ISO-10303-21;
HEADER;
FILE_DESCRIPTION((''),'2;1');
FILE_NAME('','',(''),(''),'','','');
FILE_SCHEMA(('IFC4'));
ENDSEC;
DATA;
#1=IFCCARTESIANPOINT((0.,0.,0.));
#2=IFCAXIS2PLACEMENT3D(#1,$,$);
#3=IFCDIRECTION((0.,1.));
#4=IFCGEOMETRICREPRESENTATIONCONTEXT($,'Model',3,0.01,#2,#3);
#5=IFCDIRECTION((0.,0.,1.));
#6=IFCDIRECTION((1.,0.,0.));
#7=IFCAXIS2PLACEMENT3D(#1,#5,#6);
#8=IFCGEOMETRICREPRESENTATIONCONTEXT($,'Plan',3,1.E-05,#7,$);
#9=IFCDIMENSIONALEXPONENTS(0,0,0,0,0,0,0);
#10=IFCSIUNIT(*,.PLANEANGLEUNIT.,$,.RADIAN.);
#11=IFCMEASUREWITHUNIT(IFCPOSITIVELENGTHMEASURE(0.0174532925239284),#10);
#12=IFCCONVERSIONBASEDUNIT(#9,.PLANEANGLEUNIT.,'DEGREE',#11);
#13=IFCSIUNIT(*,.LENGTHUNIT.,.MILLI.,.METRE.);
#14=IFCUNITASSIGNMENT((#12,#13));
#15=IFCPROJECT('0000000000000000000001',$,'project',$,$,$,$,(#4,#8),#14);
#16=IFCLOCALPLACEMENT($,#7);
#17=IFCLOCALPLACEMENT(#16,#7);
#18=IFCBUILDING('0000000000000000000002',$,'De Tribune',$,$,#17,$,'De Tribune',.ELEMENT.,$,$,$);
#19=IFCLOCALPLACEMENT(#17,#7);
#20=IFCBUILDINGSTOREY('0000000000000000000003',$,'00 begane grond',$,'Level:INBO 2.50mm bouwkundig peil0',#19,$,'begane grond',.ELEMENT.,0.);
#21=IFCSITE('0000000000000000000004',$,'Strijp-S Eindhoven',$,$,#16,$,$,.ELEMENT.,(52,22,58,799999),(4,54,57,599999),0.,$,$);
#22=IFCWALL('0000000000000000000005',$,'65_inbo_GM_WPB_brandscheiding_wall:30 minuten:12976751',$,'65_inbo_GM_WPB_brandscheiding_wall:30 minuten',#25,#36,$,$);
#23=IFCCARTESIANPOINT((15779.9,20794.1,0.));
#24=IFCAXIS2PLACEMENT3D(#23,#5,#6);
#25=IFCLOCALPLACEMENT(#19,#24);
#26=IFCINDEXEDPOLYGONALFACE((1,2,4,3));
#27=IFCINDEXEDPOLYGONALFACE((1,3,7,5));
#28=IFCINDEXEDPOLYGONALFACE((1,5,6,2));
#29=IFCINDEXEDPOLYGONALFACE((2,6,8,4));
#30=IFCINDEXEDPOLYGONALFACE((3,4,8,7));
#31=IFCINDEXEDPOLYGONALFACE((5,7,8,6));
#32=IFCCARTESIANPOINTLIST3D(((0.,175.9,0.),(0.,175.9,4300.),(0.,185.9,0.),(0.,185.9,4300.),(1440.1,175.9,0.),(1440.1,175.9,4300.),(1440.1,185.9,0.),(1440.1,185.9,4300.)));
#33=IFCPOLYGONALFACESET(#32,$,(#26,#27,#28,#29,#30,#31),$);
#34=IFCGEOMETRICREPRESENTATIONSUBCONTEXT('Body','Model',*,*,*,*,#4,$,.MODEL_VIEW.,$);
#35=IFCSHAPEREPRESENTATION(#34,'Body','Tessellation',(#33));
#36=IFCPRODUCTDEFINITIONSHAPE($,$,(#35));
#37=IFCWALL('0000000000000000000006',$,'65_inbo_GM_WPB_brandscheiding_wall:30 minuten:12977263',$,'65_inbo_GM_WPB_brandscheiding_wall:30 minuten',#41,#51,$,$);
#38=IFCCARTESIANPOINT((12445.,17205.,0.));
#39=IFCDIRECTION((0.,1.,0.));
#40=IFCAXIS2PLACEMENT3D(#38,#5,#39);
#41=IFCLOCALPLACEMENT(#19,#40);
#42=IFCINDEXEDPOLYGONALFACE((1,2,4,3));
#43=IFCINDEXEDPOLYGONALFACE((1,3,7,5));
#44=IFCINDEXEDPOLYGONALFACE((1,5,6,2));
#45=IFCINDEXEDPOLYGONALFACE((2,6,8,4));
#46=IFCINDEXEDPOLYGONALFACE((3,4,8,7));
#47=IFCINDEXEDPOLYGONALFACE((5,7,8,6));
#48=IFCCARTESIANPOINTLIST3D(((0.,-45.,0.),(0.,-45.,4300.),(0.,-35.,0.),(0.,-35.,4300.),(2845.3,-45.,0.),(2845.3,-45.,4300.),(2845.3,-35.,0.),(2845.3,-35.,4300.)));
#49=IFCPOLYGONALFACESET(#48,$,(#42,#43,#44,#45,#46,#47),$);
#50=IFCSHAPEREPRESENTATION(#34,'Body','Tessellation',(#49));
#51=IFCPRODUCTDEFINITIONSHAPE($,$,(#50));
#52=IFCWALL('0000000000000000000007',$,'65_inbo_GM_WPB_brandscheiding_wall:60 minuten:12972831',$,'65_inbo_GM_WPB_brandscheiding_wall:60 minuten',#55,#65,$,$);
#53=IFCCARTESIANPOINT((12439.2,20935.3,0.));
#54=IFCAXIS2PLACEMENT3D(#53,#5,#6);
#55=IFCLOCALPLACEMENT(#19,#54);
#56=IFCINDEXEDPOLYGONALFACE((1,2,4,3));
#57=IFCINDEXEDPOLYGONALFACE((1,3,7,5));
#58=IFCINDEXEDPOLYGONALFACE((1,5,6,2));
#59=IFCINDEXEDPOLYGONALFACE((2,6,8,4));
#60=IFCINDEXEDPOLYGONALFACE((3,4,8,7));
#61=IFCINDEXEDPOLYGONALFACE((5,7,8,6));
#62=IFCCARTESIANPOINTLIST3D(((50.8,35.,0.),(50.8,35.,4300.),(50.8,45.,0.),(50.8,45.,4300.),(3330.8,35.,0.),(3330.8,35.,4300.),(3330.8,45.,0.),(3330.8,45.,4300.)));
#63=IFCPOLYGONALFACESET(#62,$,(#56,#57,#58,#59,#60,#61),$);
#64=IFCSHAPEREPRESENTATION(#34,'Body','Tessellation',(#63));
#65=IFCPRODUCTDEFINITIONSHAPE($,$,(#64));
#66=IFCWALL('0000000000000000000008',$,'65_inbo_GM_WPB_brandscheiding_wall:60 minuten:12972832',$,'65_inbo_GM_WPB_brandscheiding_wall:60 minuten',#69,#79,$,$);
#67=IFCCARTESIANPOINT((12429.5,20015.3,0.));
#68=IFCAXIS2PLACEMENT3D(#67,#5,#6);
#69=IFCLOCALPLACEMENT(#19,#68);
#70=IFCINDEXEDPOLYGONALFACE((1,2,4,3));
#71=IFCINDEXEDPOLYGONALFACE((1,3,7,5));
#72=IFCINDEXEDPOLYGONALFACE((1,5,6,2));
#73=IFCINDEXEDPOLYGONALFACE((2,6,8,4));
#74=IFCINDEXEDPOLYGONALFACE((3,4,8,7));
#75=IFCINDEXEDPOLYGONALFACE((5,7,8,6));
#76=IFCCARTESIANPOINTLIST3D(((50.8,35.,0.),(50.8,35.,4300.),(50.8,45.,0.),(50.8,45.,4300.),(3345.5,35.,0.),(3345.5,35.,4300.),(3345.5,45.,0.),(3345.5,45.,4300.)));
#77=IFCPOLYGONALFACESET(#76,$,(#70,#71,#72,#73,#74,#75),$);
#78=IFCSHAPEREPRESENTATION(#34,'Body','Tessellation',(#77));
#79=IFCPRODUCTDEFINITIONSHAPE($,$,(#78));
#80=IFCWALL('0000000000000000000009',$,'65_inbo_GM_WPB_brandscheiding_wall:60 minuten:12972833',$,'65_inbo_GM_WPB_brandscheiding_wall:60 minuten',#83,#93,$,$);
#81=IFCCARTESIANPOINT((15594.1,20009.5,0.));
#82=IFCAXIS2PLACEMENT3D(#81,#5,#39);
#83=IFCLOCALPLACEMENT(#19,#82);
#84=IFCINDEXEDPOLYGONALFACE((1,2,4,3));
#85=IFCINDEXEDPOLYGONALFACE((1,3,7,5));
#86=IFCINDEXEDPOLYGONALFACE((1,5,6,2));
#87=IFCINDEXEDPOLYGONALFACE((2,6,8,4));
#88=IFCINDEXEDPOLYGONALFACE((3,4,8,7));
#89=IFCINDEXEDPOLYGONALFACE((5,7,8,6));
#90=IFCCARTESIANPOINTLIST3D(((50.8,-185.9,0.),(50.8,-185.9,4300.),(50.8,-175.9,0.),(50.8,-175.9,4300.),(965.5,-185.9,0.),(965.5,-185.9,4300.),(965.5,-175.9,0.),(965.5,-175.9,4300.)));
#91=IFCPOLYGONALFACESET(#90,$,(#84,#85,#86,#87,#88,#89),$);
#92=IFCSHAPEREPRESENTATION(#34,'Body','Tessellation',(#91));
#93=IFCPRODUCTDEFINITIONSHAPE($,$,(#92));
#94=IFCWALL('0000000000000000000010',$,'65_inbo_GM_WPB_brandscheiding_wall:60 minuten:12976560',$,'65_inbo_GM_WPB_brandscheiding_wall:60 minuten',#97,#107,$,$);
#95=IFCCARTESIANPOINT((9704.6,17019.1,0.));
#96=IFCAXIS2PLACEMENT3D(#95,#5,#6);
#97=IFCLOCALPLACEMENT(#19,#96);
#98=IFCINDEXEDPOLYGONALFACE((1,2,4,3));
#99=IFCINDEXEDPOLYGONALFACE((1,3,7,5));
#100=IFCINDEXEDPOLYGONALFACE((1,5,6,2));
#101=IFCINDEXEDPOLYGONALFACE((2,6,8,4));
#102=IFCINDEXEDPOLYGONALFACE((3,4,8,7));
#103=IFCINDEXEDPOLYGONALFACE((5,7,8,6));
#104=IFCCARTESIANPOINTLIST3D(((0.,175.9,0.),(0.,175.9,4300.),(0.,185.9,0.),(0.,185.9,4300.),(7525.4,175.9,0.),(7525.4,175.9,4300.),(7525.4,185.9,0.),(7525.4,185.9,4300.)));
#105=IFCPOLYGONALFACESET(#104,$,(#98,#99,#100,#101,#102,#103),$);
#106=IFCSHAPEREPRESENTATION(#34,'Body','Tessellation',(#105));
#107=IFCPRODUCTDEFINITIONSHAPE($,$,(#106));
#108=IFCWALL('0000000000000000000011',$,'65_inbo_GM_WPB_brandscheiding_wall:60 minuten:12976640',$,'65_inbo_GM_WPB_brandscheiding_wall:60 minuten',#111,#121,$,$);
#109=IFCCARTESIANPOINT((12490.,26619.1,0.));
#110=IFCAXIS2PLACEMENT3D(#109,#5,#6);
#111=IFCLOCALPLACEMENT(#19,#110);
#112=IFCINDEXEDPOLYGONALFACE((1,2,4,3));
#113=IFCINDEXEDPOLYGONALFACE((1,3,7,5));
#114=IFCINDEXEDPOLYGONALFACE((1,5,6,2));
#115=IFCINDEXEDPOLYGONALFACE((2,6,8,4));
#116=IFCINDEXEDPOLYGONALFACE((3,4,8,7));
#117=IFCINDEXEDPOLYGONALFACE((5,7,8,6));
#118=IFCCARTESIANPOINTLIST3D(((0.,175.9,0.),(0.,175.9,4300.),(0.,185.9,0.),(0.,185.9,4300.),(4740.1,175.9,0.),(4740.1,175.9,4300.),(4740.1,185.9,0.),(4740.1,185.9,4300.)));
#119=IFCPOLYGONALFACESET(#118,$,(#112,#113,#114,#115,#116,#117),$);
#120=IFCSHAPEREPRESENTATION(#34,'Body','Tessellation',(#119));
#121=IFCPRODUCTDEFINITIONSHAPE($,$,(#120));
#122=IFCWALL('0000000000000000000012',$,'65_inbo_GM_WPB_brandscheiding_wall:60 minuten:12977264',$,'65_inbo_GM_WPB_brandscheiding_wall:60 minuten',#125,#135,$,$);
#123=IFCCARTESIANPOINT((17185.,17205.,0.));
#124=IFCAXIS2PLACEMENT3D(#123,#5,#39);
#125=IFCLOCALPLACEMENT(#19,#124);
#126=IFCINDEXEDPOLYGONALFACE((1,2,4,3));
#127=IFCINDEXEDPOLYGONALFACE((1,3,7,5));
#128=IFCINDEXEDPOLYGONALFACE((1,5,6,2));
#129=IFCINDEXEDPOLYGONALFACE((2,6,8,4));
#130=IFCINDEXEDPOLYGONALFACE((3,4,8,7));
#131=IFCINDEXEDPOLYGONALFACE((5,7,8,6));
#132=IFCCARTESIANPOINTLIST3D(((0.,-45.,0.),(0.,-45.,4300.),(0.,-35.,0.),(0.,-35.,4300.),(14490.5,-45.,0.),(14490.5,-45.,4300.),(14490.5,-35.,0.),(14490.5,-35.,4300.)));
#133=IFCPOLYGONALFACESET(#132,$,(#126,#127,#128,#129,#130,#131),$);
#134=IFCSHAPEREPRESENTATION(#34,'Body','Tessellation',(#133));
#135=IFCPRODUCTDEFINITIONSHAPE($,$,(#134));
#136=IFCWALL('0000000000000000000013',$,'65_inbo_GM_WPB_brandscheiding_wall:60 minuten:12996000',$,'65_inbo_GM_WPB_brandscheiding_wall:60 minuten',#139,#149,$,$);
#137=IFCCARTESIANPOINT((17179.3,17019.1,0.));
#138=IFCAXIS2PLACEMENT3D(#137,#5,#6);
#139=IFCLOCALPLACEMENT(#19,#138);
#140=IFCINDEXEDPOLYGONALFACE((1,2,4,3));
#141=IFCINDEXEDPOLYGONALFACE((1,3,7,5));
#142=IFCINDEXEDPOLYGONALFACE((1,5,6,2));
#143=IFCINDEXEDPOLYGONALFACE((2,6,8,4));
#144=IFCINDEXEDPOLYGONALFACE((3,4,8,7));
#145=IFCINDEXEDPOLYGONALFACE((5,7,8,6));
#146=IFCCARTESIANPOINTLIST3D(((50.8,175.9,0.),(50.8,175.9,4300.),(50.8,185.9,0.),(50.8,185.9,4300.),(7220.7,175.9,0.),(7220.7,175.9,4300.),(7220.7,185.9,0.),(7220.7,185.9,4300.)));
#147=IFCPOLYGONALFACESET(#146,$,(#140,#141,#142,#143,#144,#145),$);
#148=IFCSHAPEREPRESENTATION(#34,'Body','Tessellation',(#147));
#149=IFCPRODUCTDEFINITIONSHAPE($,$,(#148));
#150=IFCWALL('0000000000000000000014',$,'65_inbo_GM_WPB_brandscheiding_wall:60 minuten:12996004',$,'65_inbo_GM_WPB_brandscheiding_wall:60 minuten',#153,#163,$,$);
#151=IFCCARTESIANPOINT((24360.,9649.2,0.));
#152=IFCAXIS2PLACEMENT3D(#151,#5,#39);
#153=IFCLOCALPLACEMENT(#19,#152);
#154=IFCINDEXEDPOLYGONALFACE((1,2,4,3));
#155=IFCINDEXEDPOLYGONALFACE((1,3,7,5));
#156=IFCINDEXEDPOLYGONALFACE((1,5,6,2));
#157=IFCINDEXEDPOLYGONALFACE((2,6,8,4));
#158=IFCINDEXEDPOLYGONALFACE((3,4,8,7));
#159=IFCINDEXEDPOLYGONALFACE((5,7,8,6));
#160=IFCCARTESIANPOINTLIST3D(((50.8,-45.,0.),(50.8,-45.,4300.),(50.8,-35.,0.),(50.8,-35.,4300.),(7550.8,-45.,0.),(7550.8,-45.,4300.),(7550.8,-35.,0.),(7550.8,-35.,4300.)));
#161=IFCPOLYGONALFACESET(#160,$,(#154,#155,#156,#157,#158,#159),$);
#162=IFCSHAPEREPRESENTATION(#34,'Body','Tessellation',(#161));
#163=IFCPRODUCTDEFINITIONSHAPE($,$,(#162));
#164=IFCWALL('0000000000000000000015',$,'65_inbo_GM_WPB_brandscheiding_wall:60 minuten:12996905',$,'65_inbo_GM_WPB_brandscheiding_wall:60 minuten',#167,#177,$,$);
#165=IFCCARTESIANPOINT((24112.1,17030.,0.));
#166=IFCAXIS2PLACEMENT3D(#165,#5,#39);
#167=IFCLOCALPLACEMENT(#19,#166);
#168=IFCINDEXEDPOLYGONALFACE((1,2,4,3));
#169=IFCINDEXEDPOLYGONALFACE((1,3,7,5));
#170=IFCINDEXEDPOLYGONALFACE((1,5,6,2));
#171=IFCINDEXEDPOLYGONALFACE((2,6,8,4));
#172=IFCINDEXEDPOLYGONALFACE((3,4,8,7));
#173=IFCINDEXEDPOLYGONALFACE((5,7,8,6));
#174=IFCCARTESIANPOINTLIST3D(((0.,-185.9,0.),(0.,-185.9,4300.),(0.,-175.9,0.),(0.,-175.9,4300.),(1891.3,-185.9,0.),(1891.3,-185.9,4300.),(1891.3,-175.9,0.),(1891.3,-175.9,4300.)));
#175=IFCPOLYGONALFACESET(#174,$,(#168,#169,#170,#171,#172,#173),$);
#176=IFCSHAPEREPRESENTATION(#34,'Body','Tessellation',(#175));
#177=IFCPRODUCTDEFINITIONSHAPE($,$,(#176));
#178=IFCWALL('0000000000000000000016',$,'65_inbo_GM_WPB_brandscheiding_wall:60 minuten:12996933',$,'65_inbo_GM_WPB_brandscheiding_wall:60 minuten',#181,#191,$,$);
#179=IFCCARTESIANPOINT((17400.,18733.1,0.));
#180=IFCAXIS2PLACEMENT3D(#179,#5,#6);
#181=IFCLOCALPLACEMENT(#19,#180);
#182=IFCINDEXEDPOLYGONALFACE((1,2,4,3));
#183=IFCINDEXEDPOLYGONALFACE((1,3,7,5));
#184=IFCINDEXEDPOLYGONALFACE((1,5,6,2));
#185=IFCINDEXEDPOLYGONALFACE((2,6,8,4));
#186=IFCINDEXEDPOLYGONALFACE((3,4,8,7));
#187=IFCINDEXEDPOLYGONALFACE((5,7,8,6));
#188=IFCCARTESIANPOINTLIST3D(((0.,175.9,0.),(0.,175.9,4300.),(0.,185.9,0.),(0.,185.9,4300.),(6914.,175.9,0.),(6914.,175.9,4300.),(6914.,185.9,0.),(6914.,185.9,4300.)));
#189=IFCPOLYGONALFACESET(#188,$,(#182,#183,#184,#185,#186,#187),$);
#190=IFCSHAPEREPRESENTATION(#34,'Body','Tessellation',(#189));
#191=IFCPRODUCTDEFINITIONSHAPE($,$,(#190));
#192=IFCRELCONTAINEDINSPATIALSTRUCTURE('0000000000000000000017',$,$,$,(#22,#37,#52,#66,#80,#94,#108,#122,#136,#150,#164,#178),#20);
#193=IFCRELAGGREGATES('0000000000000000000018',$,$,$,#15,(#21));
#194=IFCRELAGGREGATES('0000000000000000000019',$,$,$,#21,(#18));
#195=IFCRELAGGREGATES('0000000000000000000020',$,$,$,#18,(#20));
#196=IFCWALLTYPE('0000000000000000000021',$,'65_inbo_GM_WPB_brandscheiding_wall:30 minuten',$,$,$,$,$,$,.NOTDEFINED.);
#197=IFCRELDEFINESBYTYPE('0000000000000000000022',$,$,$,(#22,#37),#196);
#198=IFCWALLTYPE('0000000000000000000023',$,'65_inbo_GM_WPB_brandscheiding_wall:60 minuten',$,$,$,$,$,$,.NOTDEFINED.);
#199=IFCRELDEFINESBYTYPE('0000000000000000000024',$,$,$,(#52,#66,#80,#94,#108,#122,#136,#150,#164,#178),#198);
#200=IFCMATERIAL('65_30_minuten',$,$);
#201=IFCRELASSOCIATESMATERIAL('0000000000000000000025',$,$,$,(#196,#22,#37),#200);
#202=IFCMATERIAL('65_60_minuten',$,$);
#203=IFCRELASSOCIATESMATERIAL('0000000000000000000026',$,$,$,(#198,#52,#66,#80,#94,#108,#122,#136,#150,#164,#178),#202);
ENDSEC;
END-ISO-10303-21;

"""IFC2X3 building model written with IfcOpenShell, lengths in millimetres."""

from ifc_helpers import new_model, entity, si_unit, converted_unit, direction, frame, frame_2d, origin, origin_with_axes, origin_2d_with_axis, place, context, subcontext, project, spatial, rectangle, extrude, material, type_object, element, save


model = new_model("IFC2X3")

# Units and contexts
model_context = context("Model", 3, precision=0.01, world=origin(), true_north=direction((0.0, 1.0)))
plan_context = context("Plan", 3, precision=1e-05, world=origin_with_axes())
body_context = subcontext(model_context, "Body", "Model", "MODEL_VIEW")
ifc_project = project(units=[converted_unit("PLANEANGLEUNIT", "DEGREE", entity("IfcPositiveLengthMeasure", 0.0174532925239284), si_unit("PLANEANGLEUNIT", "RADIAN"), dimensions=[0, 0, 0, 0, 0, 0, 0]), si_unit("LENGTHUNIT", "METRE", prefix="MILLI")], contexts=[model_context, plan_context])

# Site, building, storey
site_placement = place(None, origin_with_axes())
site = spatial("IfcSite", under=ifc_project, at=site_placement, Name="Strijp-S Eindhoven", CompositionType="ELEMENT", RefLatitude=(52, 22, 58, 799999), RefLongitude=(4, 54, 57, 599999), RefElevation=0.0)
building_placement = place(site_placement, origin_with_axes())
building = spatial("IfcBuilding", under=site, at=building_placement, Name="De Tribune", LongName="De Tribune", CompositionType="ELEMENT")
storey_placement = place(building_placement, origin_with_axes())
storey = spatial("IfcBuildingStorey", under=building, at=storey_placement, Name="00 begane grond", ObjectType="Level:INBO 2.50mm bouwkundig peil0", LongName="begane grond", CompositionType="ELEMENT", Elevation=0.0)

# Shared definitions
ifc_material_1 = material(Name="65_60_minuten")

# Walls
ifc_material_2 = material(Name="65_30_minuten")
wall_type_1 = type_object("IfcWallType", Name="65_inbo_GM_WPB_brandscheiding_wall:30 minuten", PredefinedType="NOTDEFINED", material=ifc_material_2)
wall_1_placement = place(storey_placement, frame((15779.9, 20794.1, 0.0), z_axis=(0.0, 0.0, 1.0), x_axis=(1.0, 0.0, 0.0)))
element("IfcWall", 1, at=wall_1_placement, inside=storey, type_object=wall_type_1, material=ifc_material_2, Name="65_inbo_GM_WPB_brandscheiding_wall:30 minuten:12976751", ObjectType="65_inbo_GM_WPB_brandscheiding_wall:30 minuten", context=body_context, shape_type="SweptSolid", body=[
    extrude(rectangle(XDim=10.0, YDim=1440.1, at=frame_2d((0.0, 0.0), x_axis=(1.0, 0.0))), frame((720.1, 180.9, 0.0), z_axis=(0.0, 0.0, 1.0), x_axis=(0.0, -1.0, 0.0)), (0.0, 0.0, 1.0), 4300.0),
])
wall_2_placement = place(storey_placement, frame((12445.0, 17205.0, 0.0), z_axis=(0.0, 0.0, 1.0), x_axis=(0.0, 1.0, 0.0)))
element("IfcWall", 2, at=wall_2_placement, inside=storey, type_object=wall_type_1, material=ifc_material_2, Name="65_inbo_GM_WPB_brandscheiding_wall:30 minuten:12977263", ObjectType="65_inbo_GM_WPB_brandscheiding_wall:30 minuten", context=body_context, shape_type="SweptSolid", body=[
    extrude(rectangle(XDim=10.0, YDim=2845.3, at=origin_2d_with_axis()), frame((1422.6, -40.0, 0.0), z_axis=(0.0, 0.0, 1.0), x_axis=(0.0, -1.0, 0.0)), (0.0, 0.0, 1.0), 4300.0),
])
wall_type_2 = type_object("IfcWallType", Name="65_inbo_GM_WPB_brandscheiding_wall:60 minuten", PredefinedType="NOTDEFINED", material=ifc_material_1)
wall_3_placement = place(storey_placement, frame((12439.2, 20935.3, 0.0), z_axis=(0.0, 0.0, 1.0), x_axis=(1.0, 0.0, 0.0)))
element("IfcWall", 3, at=wall_3_placement, inside=storey, type_object=wall_type_2, material=ifc_material_1, Name="65_inbo_GM_WPB_brandscheiding_wall:60 minuten:12972831", ObjectType="65_inbo_GM_WPB_brandscheiding_wall:60 minuten", context=body_context, shape_type="SweptSolid", body=[
    extrude(rectangle(XDim=10.0, YDim=3280.0, at=frame_2d((0.0, 0.0), x_axis=(1.0, 0.0))), frame((1690.8, 40.0, 0.0), z_axis=(0.0, 0.0, 1.0), x_axis=(0.0, 1.0, 0.0)), (0.0, 0.0, 1.0), 4300.0),
])
wall_4_placement = place(storey_placement, frame((12429.5, 20015.3, 0.0), z_axis=(0.0, 0.0, 1.0), x_axis=(1.0, 0.0, 0.0)))
element("IfcWall", 4, at=wall_4_placement, inside=storey, type_object=wall_type_2, material=ifc_material_1, Name="65_inbo_GM_WPB_brandscheiding_wall:60 minuten:12972832", ObjectType="65_inbo_GM_WPB_brandscheiding_wall:60 minuten", context=body_context, shape_type="SweptSolid", body=[
    extrude(rectangle(XDim=10.0, YDim=3294.7, at=frame_2d((0.0, 0.0), x_axis=(1.0, 0.0))), frame((1698.2, 40.0, 0.0), z_axis=(0.0, 0.0, 1.0), x_axis=(0.0, 1.0, 0.0)), (0.0, 0.0, 1.0), 4300.0),
])
wall_5_placement = place(storey_placement, frame((15594.1, 20009.5, 0.0), z_axis=(0.0, 0.0, 1.0), x_axis=(0.0, 1.0, 0.0)))
element("IfcWall", 5, at=wall_5_placement, inside=storey, type_object=wall_type_2, material=ifc_material_1, Name="65_inbo_GM_WPB_brandscheiding_wall:60 minuten:12972833", ObjectType="65_inbo_GM_WPB_brandscheiding_wall:60 minuten", context=body_context, shape_type="SweptSolid", body=[
    extrude(rectangle(XDim=10.0, YDim=914.7, at=origin_2d_with_axis()), frame((508.2, -180.9, 0.0), z_axis=(0.0, 0.0, 1.0), x_axis=(0.0, 1.0, 0.0)), (0.0, 0.0, 1.0), 4300.0),
])
wall_6_placement = place(storey_placement, frame((9704.6, 17019.1, 0.0), z_axis=(0.0, 0.0, 1.0), x_axis=(1.0, 0.0, 0.0)))
element("IfcWall", 6, at=wall_6_placement, inside=storey, type_object=wall_type_2, material=ifc_material_1, Name="65_inbo_GM_WPB_brandscheiding_wall:60 minuten:12976560", ObjectType="65_inbo_GM_WPB_brandscheiding_wall:60 minuten", context=body_context, shape_type="SweptSolid", body=[
    extrude(rectangle(XDim=10.0, YDim=7525.4, at=frame_2d((0.0, 0.0), x_axis=(1.0, 0.0))), frame((3762.7, 180.9, 0.0), z_axis=(0.0, 0.0, 1.0), x_axis=(0.0, -1.0, 0.0)), (0.0, 0.0, 1.0), 4300.0),
])
wall_7_placement = place(storey_placement, frame((12490.0, 26619.1, 0.0), z_axis=(0.0, 0.0, 1.0), x_axis=(1.0, 0.0, 0.0)))
element("IfcWall", 7, at=wall_7_placement, inside=storey, type_object=wall_type_2, material=ifc_material_1, Name="65_inbo_GM_WPB_brandscheiding_wall:60 minuten:12976640", ObjectType="65_inbo_GM_WPB_brandscheiding_wall:60 minuten", context=body_context, shape_type="SweptSolid", body=[
    extrude(rectangle(XDim=10.0, YDim=4740.1, at=frame_2d((0.0, 0.0), x_axis=(1.0, 0.0))), frame((2370.1, 180.9, 0.0), z_axis=(0.0, 0.0, 1.0), x_axis=(0.0, -1.0, 0.0)), (0.0, 0.0, 1.0), 4300.0),
])
wall_8_placement = place(storey_placement, frame((17185.0, 17205.0, 0.0), z_axis=(0.0, 0.0, 1.0), x_axis=(0.0, 1.0, 0.0)))
element("IfcWall", 8, at=wall_8_placement, inside=storey, type_object=wall_type_2, material=ifc_material_1, Name="65_inbo_GM_WPB_brandscheiding_wall:60 minuten:12977264", ObjectType="65_inbo_GM_WPB_brandscheiding_wall:60 minuten", context=body_context, shape_type="SweptSolid", body=[
    extrude(rectangle(XDim=10.0, YDim=14490.5, at=frame_2d((0.0, 0.0), x_axis=(1.0, 0.0))), frame((7245.3, -40.0, 0.0), z_axis=(0.0, 0.0, 1.0), x_axis=(0.0, -1.0, 0.0)), (0.0, 0.0, 1.0), 4300.0),
])
wall_9_placement = place(storey_placement, frame((17179.3, 17019.1, 0.0), z_axis=(0.0, 0.0, 1.0), x_axis=(1.0, 0.0, 0.0)))
element("IfcWall", 9, at=wall_9_placement, inside=storey, type_object=wall_type_2, material=ifc_material_1, Name="65_inbo_GM_WPB_brandscheiding_wall:60 minuten:12996000", ObjectType="65_inbo_GM_WPB_brandscheiding_wall:60 minuten", context=body_context, shape_type="SweptSolid", body=[
    extrude(rectangle(XDim=7169.9, YDim=10.0, at=origin_2d_with_axis()), frame((3635.8, 180.9, 0.0), z_axis=(0.0, 0.0, 1.0), x_axis=(-1.0, 0.0, 0.0)), (0.0, 0.0, 1.0), 4300.0),
])
wall_10_placement = place(storey_placement, frame((24360.0, 9649.2, 0.0), z_axis=(0.0, 0.0, 1.0), x_axis=(0.0, 1.0, 0.0)))
element("IfcWall", 10, at=wall_10_placement, inside=storey, type_object=wall_type_2, material=ifc_material_1, Name="65_inbo_GM_WPB_brandscheiding_wall:60 minuten:12996004", ObjectType="65_inbo_GM_WPB_brandscheiding_wall:60 minuten", context=body_context, shape_type="SweptSolid", body=[
    extrude(rectangle(XDim=7500.0, YDim=10.0, at=frame_2d((0.0, 0.0), x_axis=(1.0, 0.0))), frame((3800.8, -40.0, 0.0), z_axis=(0.0, 0.0, 1.0), x_axis=(-1.0, 0.0, 0.0)), (0.0, 0.0, 1.0), 4300.0),
])
wall_11_placement = place(storey_placement, frame((24112.1, 17030.0, 0.0), z_axis=(0.0, 0.0, 1.0), x_axis=(0.0, 1.0, 0.0)))
element("IfcWall", 11, at=wall_11_placement, inside=storey, type_object=wall_type_2, material=ifc_material_1, Name="65_inbo_GM_WPB_brandscheiding_wall:60 minuten:12996905", ObjectType="65_inbo_GM_WPB_brandscheiding_wall:60 minuten", context=body_context, shape_type="SweptSolid", body=[
    extrude(rectangle(XDim=1891.3, YDim=10.0, at=frame_2d((0.0, 0.0), x_axis=(1.0, 0.0))), frame((945.7, -180.9, 0.0)), (0.0, 0.0, 1.0), 4300.0),
])
wall_12_placement = place(storey_placement, frame((17400.0, 18733.1, 0.0), z_axis=(0.0, 0.0, 1.0), x_axis=(1.0, 0.0, 0.0)))
element("IfcWall", 12, at=wall_12_placement, inside=storey, type_object=wall_type_2, material=ifc_material_1, Name="65_inbo_GM_WPB_brandscheiding_wall:60 minuten:12996933", ObjectType="65_inbo_GM_WPB_brandscheiding_wall:60 minuten", context=body_context, shape_type="SweptSolid", body=[
    extrude(rectangle(XDim=10.0, YDim=6914.0, at=frame_2d((0.0, 0.0), x_axis=(1.0, 0.0))), frame((3457.0, 180.9, 0.0), z_axis=(0.0, 0.0, 1.0), x_axis=(0.0, -1.0, 0.0)), (0.0, 0.0, 1.0), 4300.0),
])

save(model, "model.ifc")
